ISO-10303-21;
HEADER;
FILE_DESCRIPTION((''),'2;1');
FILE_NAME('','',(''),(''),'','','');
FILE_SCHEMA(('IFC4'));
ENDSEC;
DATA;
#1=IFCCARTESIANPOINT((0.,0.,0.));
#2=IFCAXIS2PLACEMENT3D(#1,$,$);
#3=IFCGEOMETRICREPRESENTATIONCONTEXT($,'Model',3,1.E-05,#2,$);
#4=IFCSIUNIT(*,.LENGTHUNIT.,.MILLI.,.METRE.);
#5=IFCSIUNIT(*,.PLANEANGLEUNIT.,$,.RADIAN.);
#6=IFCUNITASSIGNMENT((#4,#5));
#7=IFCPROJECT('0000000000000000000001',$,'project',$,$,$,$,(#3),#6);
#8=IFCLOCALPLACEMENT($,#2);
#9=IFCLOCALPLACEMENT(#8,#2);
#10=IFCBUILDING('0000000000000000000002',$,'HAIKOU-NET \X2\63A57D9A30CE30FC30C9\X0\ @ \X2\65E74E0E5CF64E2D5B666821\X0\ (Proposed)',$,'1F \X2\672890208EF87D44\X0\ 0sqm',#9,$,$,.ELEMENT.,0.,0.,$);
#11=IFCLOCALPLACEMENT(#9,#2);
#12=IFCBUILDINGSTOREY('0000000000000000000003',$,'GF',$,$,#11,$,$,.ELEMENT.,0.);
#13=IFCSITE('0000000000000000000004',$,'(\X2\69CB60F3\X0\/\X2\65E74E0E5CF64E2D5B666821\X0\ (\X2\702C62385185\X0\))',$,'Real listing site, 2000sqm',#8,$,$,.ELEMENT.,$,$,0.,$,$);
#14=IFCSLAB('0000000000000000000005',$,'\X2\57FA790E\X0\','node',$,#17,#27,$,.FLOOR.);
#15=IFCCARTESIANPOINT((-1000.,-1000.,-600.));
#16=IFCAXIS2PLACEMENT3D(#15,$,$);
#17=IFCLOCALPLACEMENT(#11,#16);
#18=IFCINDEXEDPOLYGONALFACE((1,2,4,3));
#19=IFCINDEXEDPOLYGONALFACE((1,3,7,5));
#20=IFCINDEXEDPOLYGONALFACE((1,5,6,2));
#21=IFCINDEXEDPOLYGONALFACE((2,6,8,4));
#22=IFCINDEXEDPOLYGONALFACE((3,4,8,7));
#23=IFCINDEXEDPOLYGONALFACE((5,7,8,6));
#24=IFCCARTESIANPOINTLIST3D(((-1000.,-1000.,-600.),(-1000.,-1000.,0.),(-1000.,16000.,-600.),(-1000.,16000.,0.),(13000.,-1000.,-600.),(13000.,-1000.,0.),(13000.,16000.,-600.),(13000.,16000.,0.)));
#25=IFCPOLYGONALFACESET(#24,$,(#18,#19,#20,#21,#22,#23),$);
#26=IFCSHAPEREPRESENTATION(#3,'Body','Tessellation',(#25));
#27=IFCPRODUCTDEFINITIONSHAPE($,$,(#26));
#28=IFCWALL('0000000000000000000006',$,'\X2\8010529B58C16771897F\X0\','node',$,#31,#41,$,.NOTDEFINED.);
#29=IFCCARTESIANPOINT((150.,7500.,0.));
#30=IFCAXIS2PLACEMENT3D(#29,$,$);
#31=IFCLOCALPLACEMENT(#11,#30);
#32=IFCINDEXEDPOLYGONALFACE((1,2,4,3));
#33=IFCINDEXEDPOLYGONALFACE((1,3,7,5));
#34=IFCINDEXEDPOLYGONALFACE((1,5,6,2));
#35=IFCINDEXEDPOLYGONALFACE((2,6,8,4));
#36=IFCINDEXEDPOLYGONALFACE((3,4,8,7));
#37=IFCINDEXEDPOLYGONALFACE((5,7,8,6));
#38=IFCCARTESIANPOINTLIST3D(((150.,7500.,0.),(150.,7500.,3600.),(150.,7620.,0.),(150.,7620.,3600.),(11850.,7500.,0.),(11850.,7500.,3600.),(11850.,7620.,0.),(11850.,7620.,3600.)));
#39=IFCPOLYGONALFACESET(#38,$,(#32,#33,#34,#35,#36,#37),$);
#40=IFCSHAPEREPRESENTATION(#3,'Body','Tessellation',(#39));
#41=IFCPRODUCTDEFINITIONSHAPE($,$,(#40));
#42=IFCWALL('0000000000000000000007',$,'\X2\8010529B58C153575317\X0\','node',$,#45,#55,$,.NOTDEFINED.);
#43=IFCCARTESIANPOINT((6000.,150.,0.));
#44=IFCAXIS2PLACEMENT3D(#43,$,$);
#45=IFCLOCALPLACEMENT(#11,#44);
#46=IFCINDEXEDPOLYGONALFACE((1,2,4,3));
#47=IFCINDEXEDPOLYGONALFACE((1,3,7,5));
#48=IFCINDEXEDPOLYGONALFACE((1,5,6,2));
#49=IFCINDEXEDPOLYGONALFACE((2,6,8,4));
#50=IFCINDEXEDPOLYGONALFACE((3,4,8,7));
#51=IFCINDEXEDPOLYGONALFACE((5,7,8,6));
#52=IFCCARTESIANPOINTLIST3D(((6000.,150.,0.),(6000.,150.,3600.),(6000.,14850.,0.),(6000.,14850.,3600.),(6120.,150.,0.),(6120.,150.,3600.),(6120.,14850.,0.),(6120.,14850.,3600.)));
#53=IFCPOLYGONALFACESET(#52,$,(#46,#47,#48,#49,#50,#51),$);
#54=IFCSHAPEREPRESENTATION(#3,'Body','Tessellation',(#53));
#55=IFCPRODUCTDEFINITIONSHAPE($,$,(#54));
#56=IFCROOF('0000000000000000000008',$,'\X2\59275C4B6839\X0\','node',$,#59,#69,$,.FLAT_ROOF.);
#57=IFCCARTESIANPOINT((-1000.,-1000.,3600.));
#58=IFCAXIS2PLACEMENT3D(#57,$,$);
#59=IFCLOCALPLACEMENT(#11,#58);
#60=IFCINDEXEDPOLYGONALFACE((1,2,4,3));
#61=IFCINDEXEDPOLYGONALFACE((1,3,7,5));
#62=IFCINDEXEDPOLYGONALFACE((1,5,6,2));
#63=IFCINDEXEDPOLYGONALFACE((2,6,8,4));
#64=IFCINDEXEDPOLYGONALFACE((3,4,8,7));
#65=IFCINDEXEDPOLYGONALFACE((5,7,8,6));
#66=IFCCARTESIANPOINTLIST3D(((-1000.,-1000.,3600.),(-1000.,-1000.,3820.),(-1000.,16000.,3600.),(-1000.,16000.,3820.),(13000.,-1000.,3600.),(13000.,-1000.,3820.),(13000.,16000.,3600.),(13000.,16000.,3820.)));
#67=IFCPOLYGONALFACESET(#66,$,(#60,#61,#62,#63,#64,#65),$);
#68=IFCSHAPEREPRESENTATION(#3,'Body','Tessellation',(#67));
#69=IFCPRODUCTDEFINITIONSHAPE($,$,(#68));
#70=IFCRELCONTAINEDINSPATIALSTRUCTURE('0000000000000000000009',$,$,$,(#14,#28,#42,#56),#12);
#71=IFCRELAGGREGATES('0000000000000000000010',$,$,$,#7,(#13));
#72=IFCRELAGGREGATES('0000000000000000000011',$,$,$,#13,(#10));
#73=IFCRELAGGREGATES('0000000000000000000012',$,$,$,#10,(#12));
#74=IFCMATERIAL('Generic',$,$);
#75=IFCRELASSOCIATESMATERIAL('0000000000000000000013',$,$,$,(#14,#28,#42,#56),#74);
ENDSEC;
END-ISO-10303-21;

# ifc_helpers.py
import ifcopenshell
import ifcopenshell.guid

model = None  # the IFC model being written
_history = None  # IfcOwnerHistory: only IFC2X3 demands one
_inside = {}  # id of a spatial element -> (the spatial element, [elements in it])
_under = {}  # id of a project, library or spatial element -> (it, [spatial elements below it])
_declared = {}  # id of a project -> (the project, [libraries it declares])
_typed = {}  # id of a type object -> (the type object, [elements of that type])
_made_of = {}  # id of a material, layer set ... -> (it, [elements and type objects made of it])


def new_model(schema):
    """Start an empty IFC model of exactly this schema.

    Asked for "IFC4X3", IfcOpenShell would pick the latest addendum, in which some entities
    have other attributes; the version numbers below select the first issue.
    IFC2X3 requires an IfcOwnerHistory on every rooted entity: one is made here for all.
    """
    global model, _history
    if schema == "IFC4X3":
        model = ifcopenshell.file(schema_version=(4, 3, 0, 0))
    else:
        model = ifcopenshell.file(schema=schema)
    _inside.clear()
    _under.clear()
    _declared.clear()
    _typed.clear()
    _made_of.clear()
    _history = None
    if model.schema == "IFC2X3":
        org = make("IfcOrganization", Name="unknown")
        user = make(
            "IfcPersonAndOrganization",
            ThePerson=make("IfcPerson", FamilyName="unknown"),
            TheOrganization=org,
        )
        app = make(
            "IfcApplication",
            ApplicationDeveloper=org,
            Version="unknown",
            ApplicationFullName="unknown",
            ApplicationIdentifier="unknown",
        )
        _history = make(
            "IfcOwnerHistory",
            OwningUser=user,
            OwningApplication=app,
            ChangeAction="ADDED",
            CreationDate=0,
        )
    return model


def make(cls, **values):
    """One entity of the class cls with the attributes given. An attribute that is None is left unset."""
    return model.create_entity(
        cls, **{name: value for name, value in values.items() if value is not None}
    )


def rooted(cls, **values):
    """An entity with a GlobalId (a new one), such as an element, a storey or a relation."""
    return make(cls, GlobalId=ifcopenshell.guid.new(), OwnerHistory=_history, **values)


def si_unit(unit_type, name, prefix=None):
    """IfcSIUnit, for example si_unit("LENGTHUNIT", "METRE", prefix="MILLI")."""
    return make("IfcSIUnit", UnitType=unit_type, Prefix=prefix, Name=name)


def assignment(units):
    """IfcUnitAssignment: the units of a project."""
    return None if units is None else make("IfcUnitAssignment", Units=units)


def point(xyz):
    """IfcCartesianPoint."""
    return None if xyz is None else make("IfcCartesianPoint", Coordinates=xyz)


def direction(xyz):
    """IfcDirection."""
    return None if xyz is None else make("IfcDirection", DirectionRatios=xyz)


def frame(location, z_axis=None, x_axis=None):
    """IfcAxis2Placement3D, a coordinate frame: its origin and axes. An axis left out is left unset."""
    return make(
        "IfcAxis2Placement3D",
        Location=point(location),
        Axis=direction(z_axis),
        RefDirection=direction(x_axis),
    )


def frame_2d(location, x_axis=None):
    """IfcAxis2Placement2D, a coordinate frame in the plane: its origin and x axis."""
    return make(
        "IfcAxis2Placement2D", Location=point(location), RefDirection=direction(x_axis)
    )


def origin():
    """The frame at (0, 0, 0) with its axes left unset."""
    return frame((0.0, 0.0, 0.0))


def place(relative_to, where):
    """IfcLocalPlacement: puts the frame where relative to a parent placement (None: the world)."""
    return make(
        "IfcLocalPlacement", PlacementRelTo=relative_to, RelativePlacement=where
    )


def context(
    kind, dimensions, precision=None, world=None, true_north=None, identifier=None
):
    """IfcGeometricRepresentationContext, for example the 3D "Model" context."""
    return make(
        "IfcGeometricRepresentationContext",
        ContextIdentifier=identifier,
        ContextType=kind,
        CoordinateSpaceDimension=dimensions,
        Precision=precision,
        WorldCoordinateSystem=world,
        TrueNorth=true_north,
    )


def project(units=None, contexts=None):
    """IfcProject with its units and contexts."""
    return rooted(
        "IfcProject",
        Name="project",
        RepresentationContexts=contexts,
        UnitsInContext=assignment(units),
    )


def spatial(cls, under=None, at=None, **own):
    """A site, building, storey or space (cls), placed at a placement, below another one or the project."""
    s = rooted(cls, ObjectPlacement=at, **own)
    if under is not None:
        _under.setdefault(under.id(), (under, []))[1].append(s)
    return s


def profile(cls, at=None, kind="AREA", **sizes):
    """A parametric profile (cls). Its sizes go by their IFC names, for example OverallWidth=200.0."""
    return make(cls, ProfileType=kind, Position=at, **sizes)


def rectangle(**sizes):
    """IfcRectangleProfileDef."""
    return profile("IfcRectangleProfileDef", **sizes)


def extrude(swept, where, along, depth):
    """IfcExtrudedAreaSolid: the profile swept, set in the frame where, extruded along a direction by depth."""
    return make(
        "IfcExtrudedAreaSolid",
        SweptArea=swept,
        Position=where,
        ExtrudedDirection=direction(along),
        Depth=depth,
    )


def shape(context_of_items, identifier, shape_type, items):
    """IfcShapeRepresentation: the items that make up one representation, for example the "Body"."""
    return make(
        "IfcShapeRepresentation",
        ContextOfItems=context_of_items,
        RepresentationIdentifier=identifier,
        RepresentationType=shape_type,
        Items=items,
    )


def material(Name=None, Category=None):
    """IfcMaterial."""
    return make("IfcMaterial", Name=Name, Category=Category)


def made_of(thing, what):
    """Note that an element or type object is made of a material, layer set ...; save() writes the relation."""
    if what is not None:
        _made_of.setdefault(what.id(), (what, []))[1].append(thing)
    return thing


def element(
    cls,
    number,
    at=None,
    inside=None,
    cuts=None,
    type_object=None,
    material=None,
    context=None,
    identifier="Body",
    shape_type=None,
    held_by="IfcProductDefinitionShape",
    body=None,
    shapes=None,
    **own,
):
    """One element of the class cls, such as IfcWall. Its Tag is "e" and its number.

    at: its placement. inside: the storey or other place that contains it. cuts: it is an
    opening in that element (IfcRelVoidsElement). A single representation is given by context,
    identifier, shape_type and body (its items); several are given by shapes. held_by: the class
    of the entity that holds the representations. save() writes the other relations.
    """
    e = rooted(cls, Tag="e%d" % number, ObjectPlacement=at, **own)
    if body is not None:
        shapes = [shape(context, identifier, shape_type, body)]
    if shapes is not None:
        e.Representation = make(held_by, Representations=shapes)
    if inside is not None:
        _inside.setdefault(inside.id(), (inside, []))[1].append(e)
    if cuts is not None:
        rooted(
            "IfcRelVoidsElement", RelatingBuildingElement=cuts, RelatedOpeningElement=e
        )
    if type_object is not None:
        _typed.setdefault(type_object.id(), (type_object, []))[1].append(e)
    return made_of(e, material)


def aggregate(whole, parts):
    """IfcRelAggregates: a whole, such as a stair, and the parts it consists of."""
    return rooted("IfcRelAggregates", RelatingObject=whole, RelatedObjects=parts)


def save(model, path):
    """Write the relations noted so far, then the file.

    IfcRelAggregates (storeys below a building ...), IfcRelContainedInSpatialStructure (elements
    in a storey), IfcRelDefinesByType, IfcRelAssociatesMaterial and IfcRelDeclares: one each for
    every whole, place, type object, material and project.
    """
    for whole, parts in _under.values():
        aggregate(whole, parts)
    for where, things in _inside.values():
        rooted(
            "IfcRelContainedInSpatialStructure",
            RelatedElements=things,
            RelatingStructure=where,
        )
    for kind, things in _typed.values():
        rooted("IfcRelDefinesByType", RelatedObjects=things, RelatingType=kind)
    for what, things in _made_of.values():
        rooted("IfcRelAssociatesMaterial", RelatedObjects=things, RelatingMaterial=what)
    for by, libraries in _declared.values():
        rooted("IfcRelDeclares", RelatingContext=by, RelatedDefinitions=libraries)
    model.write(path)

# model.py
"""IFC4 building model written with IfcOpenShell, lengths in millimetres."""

from ifc_helpers import new_model, si_unit, frame, frame_2d, origin, place, context, project, spatial, rectangle, extrude, material, element, save


model = new_model("IFC4")

# Units and contexts
model_context = context("Model", 3, precision=1e-05, world=origin())
ifc_project = project(units=[si_unit("LENGTHUNIT", "METRE", prefix="MILLI"), si_unit("PLANEANGLEUNIT", "RADIAN")], contexts=[model_context])

# Site, building, storey
site_placement = place(None, origin())
site = spatial("IfcSite", under=ifc_project, at=site_placement, Name="(構想/旧与島中学校 (瀬戸内))", ObjectType="Real listing site, 2000sqm", CompositionType="ELEMENT", RefElevation=0.0)
building_placement = place(site_placement, origin())
building = spatial("IfcBuilding", under=site, at=building_placement, Name="HAIKOU-NET 接続ノード @ 旧与島中学校 (Proposed)", ObjectType="1F 木造軸組 0sqm", CompositionType="ELEMENT", ElevationOfRefHeight=0.0, ElevationOfTerrain=0.0)
storey_placement = place(building_placement, origin())
storey = spatial("IfcBuildingStorey", under=building, at=storey_placement, Name="GF", CompositionType="ELEMENT", Elevation=0.0)

# Slab
ifc_material = material(Name="Generic")
slab_1_placement = place(storey_placement, frame((-1000.0, -1000.0, -600.0)))
element("IfcSlab", 1, at=slab_1_placement, inside=storey, material=ifc_material, Name="基礎", Description="node", PredefinedType="FLOOR", context=model_context, shape_type="SweptSolid", body=[
    extrude(rectangle(XDim=14000.0, YDim=17000.0, at=frame_2d((7000.0, 8500.0))), frame((-1000.0, -1000.0, -600.0)), (0.0, 0.0, 1.0), 600.0),
])

# Walls
wall_1_placement = place(storey_placement, frame((150.0, 7500.0, 0.0)))
element("IfcWall", 2, at=wall_1_placement, inside=storey, material=ifc_material, Name="耐力壁東西", Description="node", PredefinedType="NOTDEFINED", context=model_context, shape_type="SweptSolid", body=[
    extrude(rectangle(XDim=11700.0, YDim=120.0, at=frame_2d((5850.0, 60.0))), frame((150.0, 7500.0, 0.0)), (0.0, 0.0, 1.0), 3600.0),
])
wall_2_placement = place(storey_placement, frame((6000.0, 150.0, 0.0)))
element("IfcWall", 3, at=wall_2_placement, inside=storey, material=ifc_material, Name="耐力壁南北", Description="node", PredefinedType="NOTDEFINED", context=model_context, shape_type="SweptSolid", body=[
    extrude(rectangle(XDim=120.0, YDim=14700.0, at=frame_2d((60.0, 7350.0))), frame((6000.0, 150.0, 0.0)), (0.0, 0.0, 1.0), 3600.0),
])

# Roof
roof_placement = place(storey_placement, frame((-1000.0, -1000.0, 3600.0)))
element("IfcRoof", 4, at=roof_placement, inside=storey, material=ifc_material, Name="大屋根", Description="node", PredefinedType="FLAT_ROOF", context=model_context, shape_type="SweptSolid", body=[
    extrude(rectangle(XDim=14000.0, YDim=17000.0, at=frame_2d((7000.0, 8500.0))), frame((-1000.0, -1000.0, 3600.0)), (0.0, 0.0, 1.0), 220.0),
])

save(model, "model.ifc")
